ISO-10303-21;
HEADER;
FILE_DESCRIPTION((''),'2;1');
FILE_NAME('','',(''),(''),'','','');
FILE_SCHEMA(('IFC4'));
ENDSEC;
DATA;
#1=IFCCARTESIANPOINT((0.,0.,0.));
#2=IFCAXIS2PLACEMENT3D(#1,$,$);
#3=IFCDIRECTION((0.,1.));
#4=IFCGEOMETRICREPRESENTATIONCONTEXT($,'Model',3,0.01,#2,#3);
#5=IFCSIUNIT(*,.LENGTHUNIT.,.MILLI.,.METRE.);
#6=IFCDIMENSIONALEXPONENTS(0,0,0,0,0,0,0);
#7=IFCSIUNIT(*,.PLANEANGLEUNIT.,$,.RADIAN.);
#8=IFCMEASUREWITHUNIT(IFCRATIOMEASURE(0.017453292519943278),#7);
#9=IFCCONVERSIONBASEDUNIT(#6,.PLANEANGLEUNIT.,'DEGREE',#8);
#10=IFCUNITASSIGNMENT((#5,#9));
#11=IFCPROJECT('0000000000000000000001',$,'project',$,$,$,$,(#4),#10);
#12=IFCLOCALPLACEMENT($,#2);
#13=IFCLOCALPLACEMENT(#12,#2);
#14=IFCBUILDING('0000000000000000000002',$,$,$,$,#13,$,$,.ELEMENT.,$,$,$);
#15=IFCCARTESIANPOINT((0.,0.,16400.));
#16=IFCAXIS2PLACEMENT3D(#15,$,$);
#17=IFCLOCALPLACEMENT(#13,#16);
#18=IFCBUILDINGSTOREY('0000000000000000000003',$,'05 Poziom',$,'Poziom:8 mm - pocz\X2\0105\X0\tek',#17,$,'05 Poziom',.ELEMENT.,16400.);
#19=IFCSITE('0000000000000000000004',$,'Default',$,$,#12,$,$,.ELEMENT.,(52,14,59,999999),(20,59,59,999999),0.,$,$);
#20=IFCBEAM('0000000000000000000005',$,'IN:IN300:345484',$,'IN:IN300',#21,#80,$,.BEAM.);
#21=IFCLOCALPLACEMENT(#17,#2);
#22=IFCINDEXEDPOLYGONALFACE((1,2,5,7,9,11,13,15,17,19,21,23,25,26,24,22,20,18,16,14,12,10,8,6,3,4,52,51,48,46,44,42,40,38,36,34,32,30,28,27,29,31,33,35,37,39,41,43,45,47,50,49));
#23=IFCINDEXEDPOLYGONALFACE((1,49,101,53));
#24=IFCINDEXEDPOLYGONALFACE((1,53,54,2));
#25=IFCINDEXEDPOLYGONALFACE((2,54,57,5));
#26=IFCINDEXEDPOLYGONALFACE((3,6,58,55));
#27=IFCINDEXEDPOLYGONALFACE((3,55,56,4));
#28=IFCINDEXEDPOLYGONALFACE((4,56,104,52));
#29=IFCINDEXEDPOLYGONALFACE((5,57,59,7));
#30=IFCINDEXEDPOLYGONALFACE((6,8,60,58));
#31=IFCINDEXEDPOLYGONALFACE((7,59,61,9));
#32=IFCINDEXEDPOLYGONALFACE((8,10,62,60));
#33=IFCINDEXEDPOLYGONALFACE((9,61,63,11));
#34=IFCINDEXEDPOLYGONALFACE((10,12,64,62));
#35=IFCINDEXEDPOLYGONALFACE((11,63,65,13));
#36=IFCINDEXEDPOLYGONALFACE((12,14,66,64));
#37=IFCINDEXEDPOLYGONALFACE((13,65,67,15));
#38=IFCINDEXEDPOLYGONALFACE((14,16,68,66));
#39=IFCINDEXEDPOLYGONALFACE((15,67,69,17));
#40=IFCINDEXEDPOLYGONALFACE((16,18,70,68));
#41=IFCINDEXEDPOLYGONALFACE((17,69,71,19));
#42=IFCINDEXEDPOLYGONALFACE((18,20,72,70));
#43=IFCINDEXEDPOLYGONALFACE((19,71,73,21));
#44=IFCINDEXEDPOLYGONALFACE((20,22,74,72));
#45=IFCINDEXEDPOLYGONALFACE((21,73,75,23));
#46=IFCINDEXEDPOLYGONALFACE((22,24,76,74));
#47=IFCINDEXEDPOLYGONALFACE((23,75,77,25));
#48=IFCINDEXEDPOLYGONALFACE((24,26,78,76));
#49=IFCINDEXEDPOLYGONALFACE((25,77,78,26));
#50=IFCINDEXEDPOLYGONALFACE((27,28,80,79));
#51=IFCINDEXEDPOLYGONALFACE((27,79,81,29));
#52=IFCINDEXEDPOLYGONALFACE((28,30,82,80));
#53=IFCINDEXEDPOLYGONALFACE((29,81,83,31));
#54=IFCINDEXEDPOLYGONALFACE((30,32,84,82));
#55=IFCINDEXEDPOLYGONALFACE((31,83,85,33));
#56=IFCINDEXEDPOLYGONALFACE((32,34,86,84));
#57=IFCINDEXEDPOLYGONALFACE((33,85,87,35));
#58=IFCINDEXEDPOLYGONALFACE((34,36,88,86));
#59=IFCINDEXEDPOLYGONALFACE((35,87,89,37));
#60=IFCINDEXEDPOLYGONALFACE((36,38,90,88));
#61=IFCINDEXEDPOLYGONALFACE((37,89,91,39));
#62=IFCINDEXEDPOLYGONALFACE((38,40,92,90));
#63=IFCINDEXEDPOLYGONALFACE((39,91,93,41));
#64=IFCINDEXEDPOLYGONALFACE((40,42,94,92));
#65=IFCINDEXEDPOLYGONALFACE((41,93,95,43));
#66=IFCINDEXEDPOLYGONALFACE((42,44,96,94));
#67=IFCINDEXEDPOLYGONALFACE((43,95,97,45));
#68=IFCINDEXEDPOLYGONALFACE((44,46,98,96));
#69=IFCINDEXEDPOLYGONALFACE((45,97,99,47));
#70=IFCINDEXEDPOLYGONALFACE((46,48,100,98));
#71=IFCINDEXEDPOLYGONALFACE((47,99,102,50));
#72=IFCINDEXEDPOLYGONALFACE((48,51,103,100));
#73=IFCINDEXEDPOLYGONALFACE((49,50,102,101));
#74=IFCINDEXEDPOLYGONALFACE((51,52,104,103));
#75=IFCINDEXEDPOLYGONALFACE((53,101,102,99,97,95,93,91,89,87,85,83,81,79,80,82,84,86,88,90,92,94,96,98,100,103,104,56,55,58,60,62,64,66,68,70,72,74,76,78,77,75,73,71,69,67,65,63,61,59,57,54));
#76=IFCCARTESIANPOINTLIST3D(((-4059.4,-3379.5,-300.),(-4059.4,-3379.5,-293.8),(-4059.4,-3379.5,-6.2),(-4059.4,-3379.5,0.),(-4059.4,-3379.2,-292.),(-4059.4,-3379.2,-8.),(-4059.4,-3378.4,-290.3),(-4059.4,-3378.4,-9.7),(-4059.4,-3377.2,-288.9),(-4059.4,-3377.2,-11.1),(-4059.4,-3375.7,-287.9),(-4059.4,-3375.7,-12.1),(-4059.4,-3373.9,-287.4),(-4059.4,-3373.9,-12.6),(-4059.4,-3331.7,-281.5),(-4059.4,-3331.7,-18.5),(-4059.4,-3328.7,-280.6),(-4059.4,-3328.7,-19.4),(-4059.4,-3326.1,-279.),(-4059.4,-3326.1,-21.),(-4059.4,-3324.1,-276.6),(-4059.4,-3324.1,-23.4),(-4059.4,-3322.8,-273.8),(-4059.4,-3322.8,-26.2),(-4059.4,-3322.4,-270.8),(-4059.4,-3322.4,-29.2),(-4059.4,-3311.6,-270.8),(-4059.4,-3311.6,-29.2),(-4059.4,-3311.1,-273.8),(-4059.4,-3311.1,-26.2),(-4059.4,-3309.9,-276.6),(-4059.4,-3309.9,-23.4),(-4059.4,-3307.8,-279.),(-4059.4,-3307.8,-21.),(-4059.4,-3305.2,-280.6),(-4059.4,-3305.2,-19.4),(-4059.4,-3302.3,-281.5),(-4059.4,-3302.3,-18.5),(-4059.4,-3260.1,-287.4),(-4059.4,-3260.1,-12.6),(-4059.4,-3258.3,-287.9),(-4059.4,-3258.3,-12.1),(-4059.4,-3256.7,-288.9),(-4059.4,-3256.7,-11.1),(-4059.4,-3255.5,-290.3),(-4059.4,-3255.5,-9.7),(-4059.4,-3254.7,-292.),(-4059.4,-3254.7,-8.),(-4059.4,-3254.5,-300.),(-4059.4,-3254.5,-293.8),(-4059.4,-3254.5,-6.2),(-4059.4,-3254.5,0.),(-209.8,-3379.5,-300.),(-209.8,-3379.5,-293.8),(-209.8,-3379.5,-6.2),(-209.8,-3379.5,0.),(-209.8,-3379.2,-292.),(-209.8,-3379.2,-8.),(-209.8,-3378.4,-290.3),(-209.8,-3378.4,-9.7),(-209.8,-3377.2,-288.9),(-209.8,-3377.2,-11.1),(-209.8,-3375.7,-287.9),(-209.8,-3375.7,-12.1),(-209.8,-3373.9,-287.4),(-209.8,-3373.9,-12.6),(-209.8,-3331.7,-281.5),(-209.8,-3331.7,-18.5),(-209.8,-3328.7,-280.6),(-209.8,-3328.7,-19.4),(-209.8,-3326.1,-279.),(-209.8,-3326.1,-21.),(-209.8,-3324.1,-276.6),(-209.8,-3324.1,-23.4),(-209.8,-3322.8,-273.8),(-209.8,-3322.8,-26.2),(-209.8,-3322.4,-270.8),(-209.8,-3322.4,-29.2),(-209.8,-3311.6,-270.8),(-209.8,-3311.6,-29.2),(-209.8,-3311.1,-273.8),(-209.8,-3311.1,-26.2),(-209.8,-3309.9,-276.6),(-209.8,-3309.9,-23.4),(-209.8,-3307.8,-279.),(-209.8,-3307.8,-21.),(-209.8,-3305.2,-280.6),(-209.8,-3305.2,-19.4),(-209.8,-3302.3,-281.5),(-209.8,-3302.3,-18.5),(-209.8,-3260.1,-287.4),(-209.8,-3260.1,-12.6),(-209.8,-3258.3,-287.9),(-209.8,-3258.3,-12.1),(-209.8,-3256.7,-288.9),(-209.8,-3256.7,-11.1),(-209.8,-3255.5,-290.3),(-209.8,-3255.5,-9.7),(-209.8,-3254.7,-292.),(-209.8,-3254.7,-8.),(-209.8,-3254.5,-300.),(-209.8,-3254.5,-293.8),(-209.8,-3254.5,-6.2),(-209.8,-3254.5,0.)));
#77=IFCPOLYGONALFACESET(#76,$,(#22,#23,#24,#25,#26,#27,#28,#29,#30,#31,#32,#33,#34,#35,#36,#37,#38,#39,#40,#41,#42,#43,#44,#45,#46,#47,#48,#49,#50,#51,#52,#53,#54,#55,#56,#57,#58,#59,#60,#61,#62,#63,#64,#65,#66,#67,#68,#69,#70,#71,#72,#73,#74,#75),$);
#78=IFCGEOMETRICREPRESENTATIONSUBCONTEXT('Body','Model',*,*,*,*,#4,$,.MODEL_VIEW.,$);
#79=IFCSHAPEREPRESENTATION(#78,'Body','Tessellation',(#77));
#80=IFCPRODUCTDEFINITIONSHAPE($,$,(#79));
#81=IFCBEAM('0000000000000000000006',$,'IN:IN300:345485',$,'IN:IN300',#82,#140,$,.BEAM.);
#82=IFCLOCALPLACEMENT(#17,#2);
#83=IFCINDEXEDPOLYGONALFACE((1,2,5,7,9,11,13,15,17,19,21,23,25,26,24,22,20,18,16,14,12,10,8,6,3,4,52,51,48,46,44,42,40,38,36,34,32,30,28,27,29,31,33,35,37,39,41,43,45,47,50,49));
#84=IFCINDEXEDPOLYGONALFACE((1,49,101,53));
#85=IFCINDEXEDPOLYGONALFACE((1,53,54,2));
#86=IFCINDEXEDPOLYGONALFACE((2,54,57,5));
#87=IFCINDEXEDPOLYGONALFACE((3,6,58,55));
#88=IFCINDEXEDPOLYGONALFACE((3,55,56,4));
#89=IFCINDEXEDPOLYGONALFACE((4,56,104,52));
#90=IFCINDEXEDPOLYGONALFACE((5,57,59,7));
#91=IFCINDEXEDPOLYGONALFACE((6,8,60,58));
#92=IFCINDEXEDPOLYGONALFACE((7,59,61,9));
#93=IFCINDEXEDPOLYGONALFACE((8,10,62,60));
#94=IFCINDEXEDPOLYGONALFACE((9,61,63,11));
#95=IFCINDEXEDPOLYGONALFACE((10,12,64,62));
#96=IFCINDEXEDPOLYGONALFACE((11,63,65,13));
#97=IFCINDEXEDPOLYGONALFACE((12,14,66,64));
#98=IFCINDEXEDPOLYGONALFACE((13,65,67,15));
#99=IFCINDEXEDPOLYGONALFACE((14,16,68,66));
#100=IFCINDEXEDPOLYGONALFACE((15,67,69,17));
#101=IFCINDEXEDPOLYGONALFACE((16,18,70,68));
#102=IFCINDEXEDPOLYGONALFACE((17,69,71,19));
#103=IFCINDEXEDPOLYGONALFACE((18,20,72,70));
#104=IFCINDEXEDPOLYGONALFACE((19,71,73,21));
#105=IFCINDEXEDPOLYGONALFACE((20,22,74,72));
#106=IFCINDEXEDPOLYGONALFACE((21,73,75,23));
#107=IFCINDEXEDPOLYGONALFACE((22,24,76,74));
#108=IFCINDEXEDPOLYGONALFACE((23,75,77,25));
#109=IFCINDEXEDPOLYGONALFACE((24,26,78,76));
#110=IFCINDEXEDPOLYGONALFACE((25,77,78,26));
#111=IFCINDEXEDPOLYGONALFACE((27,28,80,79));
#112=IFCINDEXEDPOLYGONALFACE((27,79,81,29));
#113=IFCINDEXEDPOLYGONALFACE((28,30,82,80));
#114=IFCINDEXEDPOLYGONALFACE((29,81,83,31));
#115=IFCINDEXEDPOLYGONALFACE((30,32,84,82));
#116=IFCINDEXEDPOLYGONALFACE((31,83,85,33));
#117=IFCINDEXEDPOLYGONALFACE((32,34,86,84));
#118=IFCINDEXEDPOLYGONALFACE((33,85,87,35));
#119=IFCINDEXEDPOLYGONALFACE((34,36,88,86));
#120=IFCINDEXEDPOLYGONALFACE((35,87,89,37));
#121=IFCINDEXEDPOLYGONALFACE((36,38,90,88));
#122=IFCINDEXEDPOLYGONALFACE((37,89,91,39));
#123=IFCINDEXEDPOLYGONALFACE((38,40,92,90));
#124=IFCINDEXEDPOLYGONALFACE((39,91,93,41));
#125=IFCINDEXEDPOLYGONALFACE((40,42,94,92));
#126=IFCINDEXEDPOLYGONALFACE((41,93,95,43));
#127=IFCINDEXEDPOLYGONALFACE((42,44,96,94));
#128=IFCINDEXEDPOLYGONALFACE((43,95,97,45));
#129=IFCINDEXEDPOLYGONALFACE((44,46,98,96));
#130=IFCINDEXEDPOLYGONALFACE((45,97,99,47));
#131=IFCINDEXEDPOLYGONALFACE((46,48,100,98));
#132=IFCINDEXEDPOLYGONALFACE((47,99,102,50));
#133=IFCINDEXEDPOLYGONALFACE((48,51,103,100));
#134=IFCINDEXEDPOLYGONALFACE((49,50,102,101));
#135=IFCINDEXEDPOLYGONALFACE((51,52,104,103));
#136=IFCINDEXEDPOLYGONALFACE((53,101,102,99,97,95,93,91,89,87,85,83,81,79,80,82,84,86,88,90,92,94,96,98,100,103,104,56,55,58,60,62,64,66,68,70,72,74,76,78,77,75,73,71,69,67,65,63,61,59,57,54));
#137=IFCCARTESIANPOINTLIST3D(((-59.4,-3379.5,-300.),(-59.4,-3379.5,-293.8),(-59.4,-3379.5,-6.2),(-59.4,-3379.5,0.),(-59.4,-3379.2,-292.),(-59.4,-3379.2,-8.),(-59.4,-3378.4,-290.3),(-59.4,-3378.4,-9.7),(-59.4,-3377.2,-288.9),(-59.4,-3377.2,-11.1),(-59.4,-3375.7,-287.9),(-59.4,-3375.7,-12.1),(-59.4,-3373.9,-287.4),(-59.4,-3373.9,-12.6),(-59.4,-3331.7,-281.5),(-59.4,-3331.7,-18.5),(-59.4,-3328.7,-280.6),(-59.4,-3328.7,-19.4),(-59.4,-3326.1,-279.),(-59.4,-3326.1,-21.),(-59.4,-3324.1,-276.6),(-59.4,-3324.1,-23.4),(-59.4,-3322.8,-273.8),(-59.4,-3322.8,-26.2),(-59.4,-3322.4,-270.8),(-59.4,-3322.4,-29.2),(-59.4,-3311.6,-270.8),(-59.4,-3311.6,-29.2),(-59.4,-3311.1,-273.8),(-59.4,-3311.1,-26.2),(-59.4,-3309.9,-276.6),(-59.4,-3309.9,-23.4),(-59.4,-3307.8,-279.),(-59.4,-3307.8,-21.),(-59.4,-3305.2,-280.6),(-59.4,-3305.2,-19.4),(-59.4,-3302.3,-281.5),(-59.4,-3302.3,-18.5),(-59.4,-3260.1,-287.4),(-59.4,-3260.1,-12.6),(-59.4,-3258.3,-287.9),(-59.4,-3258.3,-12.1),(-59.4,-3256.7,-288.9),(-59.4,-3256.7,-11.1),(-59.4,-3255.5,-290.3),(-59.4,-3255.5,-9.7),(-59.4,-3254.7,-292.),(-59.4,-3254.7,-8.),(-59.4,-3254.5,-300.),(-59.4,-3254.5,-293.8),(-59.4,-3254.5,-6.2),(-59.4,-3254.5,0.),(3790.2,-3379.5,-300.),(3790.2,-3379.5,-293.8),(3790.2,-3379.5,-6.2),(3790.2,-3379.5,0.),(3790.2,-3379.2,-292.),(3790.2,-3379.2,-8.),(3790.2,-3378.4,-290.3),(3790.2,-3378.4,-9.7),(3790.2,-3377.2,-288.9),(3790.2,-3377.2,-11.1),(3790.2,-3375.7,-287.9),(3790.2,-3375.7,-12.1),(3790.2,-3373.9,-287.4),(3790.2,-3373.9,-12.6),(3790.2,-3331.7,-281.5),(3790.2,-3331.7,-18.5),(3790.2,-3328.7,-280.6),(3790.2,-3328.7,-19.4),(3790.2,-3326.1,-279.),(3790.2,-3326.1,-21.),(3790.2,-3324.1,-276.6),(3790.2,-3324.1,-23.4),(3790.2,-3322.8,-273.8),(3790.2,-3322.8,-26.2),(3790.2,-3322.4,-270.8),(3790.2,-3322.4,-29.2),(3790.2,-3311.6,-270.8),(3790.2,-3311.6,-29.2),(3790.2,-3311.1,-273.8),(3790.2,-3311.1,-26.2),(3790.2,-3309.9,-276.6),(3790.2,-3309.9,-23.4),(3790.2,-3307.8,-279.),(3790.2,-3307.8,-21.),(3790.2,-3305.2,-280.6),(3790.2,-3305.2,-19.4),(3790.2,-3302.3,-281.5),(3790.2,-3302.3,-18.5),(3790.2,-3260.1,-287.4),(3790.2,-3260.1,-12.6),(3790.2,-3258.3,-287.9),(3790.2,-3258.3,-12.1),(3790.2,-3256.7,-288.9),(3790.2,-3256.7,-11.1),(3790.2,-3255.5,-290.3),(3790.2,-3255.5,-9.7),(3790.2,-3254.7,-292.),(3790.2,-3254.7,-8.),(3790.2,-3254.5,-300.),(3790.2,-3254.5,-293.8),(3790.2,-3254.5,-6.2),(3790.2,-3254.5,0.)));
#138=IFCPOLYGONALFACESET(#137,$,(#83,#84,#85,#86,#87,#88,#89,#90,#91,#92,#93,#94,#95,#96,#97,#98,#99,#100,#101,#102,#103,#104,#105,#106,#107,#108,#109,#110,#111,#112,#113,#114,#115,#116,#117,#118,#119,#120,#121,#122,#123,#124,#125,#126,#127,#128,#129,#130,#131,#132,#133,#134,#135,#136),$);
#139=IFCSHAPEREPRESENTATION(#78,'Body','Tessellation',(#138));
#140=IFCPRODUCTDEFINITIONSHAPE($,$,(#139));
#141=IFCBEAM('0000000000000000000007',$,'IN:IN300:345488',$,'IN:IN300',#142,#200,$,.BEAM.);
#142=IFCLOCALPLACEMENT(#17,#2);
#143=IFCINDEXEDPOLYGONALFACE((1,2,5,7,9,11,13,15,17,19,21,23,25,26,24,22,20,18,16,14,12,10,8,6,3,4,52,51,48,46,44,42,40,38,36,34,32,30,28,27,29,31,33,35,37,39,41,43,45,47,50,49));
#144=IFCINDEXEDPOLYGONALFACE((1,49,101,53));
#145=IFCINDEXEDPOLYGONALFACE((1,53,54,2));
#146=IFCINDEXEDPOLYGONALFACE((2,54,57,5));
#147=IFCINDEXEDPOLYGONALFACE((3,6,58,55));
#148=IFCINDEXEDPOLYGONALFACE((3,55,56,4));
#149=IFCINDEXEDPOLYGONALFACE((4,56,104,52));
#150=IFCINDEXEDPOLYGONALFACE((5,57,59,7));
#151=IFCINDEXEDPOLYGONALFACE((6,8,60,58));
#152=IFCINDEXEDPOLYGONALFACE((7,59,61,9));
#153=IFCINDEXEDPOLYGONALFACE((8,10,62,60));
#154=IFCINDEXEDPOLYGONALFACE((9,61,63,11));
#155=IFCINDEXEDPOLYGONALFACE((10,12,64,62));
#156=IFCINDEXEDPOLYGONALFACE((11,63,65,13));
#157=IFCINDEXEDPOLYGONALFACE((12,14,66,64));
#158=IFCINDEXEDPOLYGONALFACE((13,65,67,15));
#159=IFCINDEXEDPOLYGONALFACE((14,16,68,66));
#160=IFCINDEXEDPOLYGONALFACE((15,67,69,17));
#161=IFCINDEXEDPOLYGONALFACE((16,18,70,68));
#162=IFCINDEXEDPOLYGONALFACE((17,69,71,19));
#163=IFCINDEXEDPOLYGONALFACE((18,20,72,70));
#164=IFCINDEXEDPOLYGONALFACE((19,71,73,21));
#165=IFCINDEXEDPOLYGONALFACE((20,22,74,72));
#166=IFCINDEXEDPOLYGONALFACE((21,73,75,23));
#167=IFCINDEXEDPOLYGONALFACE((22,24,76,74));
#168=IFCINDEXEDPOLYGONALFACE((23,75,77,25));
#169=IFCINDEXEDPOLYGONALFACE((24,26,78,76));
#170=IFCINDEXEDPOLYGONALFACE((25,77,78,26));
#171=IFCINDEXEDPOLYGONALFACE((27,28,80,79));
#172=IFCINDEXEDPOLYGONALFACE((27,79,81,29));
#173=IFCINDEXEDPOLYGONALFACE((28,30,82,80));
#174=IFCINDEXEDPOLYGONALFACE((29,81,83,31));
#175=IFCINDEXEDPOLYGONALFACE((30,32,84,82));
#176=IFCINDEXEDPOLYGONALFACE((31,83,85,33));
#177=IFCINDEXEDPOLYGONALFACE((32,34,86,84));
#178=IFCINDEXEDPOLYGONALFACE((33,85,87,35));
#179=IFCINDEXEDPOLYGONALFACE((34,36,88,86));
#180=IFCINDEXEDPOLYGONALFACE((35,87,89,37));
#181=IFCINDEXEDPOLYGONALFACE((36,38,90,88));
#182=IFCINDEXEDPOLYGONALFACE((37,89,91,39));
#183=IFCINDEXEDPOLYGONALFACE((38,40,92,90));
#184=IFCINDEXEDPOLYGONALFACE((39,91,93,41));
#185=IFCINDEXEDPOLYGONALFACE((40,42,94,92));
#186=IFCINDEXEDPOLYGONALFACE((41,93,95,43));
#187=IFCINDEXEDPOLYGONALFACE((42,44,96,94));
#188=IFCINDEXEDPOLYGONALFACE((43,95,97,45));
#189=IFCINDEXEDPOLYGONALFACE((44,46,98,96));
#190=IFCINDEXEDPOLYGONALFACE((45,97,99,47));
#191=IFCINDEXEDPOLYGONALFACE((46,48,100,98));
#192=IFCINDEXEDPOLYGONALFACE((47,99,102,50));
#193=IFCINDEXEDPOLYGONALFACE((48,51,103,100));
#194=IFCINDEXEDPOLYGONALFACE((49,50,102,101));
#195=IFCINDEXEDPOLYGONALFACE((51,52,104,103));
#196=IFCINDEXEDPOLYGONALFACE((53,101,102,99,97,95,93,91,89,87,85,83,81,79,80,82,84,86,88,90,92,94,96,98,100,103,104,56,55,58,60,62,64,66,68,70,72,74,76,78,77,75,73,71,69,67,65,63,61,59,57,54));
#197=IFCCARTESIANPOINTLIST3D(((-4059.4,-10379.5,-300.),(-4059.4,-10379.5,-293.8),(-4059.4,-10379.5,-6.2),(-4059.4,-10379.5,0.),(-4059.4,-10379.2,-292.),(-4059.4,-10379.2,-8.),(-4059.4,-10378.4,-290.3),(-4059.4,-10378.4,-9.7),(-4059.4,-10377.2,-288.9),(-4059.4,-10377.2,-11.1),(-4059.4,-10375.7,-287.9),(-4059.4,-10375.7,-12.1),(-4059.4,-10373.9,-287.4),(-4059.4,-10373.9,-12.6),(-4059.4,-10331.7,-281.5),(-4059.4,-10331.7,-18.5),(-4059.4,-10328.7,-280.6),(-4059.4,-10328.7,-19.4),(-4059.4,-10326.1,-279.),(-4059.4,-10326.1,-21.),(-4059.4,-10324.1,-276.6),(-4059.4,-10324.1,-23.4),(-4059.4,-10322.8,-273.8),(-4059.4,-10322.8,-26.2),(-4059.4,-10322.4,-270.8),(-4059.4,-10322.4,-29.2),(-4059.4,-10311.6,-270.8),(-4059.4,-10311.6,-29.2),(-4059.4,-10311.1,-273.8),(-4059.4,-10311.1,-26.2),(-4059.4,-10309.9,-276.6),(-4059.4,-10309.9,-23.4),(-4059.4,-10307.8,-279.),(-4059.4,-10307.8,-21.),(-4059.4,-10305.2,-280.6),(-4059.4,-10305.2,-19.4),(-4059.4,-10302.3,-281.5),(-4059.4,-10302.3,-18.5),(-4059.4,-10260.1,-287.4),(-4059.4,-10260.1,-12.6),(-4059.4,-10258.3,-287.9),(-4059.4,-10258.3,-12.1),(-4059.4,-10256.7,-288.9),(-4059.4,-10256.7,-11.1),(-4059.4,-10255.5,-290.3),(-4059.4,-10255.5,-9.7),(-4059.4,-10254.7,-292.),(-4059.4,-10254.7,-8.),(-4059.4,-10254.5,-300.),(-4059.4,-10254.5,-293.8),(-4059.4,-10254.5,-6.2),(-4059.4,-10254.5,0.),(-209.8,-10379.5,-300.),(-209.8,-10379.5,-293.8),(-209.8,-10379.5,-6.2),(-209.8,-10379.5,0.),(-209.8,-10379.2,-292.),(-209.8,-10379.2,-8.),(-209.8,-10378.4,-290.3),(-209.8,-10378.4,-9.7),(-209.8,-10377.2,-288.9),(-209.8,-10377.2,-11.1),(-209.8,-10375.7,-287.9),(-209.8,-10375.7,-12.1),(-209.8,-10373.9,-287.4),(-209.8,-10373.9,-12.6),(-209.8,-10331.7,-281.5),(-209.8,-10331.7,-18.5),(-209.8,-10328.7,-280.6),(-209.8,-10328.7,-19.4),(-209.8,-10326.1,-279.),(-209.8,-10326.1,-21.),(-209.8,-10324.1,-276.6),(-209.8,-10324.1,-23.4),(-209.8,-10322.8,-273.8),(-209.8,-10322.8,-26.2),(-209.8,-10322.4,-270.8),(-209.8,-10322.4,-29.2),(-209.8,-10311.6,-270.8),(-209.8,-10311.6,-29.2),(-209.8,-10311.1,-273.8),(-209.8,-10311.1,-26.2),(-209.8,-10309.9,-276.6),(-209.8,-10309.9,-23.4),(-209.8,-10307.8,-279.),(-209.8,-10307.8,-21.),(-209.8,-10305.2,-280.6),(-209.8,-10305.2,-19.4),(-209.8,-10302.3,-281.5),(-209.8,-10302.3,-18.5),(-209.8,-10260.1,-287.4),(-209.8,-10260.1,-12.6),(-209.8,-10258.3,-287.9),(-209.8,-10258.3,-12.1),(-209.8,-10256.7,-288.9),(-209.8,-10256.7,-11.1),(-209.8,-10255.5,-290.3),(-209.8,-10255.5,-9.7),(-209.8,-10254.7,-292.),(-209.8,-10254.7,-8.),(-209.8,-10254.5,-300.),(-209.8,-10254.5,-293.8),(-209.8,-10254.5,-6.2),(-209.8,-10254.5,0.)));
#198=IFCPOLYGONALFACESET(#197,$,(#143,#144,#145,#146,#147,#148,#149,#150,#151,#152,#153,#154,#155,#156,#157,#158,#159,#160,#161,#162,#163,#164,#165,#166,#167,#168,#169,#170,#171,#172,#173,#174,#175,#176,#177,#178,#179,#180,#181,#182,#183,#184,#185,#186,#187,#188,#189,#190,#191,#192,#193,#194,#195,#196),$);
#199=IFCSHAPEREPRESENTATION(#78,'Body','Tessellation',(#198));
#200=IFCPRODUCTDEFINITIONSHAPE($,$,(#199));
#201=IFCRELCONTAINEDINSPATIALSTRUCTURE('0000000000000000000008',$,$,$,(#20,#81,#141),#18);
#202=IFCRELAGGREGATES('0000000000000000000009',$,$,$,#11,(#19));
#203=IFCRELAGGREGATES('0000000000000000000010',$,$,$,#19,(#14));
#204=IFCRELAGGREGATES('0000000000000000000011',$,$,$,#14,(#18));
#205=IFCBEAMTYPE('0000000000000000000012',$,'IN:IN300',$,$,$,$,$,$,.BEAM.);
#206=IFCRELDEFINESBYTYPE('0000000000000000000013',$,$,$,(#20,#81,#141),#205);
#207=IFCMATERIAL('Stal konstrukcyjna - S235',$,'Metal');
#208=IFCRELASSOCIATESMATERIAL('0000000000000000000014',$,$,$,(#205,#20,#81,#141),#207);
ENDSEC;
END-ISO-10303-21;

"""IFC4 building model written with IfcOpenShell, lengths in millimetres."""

from ifc_helpers import new_model, entity, si_unit, converted_unit, direction, frame, origin, place, context, subcontext, project, spatial, line, arc, indexed_curve, outline, extrude, source, transform, mapped, material, type_object, type_shapes, element, save


model = new_model("IFC4")

# Units and contexts
model_context = context("Model", 3, precision=0.01, world=origin(), true_north=direction((0.0, 1.0)))
body_context = subcontext(model_context, "Body", "Model", "MODEL_VIEW")
ifc_project = project(units=[si_unit("LENGTHUNIT", "METRE", prefix="MILLI"), converted_unit("PLANEANGLEUNIT", "DEGREE", entity("IfcRatioMeasure", 0.017453292519943278), si_unit("PLANEANGLEUNIT", "RADIAN"), dimensions=[0, 0, 0, 0, 0, 0, 0])], contexts=[model_context])

# Site, building, storey
site_placement = place(None, origin())
site = spatial("IfcSite", under=ifc_project, at=site_placement, Name="Default", CompositionType="ELEMENT", RefLatitude=(52, 14, 59, 999999), RefLongitude=(20, 59, 59, 999999), RefElevation=0.0)
building_placement = place(site_placement, origin())
building = spatial("IfcBuilding", under=site, at=building_placement, CompositionType="ELEMENT")
storey_placement = place(building_placement, frame((0.0, 0.0, 16400.0)))
storey = spatial("IfcBuildingStorey", under=building, at=storey_placement, Name="05 Poziom", ObjectType="Poziom:8 mm - początek", LongName="05 Poziom", CompositionType="ELEMENT", Elevation=16400.0)

# Shared definitions
ifc_material = material(Name="Stal konstrukcyjna - S235", Category="Metal")

# Beams
beam_type_1 = type_object("IfcBeamType", Name="IN:IN300", PredefinedType="BEAM", material=ifc_material)
shared_shape_1 = source(origin(), body_context, "Body", "SweptSolid", [
    extrude(outline(indexed_curve([(143.8, -62.5), (150.0, -62.5), (150.0, 62.5), (143.8, 62.5), (139.6, 60.9), (137.4, 56.9), (131.5, 14.7), (127.9, 8.1), (120.8, 5.4), (-120.8, 5.4), (-127.9, 8.1), (-131.5, 14.7), (-137.4, 56.9), (-139.6, 60.9), (-143.8, 62.5), (-150.0, 62.5), (-150.0, -62.5), (-143.8, -62.5), (-139.6, -60.9), (-137.4, -56.9), (-131.5, -14.7), (-127.9, -8.1), (-120.8, -5.4), (120.8, -5.4), (127.9, -8.1), (131.5, -14.7), (137.4, -56.9), (139.6, -60.9)], segments=[line(1, 2, 3, 4), arc(4, 5, 6), line(6, 7), arc(7, 8, 9), line(9, 10), arc(10, 11, 12), line(12, 13), arc(13, 14, 15), line(15, 16, 17, 18), arc(18, 19, 20), line(20, 21), arc(21, 22, 23), line(23, 24), arc(24, 25, 26), line(26, 27), arc(27, 28, 1)], self_intersect=False)), frame((-1924.8, 0.0, 0.0), z_axis=(1.0, 0.0, 0.0), x_axis=(0.0, 0.0, -1.0)), (0.0, 0.0, 1.0), 3849.6),
])
type_shapes(beam_type_1, [shared_shape_1])
for number, where, name in (
    (1, (-2134.6, -3317.0, -150.0), "IN:IN300:345484"),
    (2, (1865.4, -3317.0, -150.0), "IN:IN300:345485"),
    (3, (-2134.6, -10317.0, -150.0), "IN:IN300:345488"),
):
    element("IfcBeam", number, at=place(storey_placement, frame(where)), inside=storey, type_object=beam_type_1, material=ifc_material, Name=name, ObjectType="IN:IN300", PredefinedType="BEAM", context=body_context, shape_type="MappedRepresentation", body=[
        mapped(shared_shape_1, transform((0.0, 0.0, 0.0), scale=1.0)),
    ])

save(model, "model.ifc")
